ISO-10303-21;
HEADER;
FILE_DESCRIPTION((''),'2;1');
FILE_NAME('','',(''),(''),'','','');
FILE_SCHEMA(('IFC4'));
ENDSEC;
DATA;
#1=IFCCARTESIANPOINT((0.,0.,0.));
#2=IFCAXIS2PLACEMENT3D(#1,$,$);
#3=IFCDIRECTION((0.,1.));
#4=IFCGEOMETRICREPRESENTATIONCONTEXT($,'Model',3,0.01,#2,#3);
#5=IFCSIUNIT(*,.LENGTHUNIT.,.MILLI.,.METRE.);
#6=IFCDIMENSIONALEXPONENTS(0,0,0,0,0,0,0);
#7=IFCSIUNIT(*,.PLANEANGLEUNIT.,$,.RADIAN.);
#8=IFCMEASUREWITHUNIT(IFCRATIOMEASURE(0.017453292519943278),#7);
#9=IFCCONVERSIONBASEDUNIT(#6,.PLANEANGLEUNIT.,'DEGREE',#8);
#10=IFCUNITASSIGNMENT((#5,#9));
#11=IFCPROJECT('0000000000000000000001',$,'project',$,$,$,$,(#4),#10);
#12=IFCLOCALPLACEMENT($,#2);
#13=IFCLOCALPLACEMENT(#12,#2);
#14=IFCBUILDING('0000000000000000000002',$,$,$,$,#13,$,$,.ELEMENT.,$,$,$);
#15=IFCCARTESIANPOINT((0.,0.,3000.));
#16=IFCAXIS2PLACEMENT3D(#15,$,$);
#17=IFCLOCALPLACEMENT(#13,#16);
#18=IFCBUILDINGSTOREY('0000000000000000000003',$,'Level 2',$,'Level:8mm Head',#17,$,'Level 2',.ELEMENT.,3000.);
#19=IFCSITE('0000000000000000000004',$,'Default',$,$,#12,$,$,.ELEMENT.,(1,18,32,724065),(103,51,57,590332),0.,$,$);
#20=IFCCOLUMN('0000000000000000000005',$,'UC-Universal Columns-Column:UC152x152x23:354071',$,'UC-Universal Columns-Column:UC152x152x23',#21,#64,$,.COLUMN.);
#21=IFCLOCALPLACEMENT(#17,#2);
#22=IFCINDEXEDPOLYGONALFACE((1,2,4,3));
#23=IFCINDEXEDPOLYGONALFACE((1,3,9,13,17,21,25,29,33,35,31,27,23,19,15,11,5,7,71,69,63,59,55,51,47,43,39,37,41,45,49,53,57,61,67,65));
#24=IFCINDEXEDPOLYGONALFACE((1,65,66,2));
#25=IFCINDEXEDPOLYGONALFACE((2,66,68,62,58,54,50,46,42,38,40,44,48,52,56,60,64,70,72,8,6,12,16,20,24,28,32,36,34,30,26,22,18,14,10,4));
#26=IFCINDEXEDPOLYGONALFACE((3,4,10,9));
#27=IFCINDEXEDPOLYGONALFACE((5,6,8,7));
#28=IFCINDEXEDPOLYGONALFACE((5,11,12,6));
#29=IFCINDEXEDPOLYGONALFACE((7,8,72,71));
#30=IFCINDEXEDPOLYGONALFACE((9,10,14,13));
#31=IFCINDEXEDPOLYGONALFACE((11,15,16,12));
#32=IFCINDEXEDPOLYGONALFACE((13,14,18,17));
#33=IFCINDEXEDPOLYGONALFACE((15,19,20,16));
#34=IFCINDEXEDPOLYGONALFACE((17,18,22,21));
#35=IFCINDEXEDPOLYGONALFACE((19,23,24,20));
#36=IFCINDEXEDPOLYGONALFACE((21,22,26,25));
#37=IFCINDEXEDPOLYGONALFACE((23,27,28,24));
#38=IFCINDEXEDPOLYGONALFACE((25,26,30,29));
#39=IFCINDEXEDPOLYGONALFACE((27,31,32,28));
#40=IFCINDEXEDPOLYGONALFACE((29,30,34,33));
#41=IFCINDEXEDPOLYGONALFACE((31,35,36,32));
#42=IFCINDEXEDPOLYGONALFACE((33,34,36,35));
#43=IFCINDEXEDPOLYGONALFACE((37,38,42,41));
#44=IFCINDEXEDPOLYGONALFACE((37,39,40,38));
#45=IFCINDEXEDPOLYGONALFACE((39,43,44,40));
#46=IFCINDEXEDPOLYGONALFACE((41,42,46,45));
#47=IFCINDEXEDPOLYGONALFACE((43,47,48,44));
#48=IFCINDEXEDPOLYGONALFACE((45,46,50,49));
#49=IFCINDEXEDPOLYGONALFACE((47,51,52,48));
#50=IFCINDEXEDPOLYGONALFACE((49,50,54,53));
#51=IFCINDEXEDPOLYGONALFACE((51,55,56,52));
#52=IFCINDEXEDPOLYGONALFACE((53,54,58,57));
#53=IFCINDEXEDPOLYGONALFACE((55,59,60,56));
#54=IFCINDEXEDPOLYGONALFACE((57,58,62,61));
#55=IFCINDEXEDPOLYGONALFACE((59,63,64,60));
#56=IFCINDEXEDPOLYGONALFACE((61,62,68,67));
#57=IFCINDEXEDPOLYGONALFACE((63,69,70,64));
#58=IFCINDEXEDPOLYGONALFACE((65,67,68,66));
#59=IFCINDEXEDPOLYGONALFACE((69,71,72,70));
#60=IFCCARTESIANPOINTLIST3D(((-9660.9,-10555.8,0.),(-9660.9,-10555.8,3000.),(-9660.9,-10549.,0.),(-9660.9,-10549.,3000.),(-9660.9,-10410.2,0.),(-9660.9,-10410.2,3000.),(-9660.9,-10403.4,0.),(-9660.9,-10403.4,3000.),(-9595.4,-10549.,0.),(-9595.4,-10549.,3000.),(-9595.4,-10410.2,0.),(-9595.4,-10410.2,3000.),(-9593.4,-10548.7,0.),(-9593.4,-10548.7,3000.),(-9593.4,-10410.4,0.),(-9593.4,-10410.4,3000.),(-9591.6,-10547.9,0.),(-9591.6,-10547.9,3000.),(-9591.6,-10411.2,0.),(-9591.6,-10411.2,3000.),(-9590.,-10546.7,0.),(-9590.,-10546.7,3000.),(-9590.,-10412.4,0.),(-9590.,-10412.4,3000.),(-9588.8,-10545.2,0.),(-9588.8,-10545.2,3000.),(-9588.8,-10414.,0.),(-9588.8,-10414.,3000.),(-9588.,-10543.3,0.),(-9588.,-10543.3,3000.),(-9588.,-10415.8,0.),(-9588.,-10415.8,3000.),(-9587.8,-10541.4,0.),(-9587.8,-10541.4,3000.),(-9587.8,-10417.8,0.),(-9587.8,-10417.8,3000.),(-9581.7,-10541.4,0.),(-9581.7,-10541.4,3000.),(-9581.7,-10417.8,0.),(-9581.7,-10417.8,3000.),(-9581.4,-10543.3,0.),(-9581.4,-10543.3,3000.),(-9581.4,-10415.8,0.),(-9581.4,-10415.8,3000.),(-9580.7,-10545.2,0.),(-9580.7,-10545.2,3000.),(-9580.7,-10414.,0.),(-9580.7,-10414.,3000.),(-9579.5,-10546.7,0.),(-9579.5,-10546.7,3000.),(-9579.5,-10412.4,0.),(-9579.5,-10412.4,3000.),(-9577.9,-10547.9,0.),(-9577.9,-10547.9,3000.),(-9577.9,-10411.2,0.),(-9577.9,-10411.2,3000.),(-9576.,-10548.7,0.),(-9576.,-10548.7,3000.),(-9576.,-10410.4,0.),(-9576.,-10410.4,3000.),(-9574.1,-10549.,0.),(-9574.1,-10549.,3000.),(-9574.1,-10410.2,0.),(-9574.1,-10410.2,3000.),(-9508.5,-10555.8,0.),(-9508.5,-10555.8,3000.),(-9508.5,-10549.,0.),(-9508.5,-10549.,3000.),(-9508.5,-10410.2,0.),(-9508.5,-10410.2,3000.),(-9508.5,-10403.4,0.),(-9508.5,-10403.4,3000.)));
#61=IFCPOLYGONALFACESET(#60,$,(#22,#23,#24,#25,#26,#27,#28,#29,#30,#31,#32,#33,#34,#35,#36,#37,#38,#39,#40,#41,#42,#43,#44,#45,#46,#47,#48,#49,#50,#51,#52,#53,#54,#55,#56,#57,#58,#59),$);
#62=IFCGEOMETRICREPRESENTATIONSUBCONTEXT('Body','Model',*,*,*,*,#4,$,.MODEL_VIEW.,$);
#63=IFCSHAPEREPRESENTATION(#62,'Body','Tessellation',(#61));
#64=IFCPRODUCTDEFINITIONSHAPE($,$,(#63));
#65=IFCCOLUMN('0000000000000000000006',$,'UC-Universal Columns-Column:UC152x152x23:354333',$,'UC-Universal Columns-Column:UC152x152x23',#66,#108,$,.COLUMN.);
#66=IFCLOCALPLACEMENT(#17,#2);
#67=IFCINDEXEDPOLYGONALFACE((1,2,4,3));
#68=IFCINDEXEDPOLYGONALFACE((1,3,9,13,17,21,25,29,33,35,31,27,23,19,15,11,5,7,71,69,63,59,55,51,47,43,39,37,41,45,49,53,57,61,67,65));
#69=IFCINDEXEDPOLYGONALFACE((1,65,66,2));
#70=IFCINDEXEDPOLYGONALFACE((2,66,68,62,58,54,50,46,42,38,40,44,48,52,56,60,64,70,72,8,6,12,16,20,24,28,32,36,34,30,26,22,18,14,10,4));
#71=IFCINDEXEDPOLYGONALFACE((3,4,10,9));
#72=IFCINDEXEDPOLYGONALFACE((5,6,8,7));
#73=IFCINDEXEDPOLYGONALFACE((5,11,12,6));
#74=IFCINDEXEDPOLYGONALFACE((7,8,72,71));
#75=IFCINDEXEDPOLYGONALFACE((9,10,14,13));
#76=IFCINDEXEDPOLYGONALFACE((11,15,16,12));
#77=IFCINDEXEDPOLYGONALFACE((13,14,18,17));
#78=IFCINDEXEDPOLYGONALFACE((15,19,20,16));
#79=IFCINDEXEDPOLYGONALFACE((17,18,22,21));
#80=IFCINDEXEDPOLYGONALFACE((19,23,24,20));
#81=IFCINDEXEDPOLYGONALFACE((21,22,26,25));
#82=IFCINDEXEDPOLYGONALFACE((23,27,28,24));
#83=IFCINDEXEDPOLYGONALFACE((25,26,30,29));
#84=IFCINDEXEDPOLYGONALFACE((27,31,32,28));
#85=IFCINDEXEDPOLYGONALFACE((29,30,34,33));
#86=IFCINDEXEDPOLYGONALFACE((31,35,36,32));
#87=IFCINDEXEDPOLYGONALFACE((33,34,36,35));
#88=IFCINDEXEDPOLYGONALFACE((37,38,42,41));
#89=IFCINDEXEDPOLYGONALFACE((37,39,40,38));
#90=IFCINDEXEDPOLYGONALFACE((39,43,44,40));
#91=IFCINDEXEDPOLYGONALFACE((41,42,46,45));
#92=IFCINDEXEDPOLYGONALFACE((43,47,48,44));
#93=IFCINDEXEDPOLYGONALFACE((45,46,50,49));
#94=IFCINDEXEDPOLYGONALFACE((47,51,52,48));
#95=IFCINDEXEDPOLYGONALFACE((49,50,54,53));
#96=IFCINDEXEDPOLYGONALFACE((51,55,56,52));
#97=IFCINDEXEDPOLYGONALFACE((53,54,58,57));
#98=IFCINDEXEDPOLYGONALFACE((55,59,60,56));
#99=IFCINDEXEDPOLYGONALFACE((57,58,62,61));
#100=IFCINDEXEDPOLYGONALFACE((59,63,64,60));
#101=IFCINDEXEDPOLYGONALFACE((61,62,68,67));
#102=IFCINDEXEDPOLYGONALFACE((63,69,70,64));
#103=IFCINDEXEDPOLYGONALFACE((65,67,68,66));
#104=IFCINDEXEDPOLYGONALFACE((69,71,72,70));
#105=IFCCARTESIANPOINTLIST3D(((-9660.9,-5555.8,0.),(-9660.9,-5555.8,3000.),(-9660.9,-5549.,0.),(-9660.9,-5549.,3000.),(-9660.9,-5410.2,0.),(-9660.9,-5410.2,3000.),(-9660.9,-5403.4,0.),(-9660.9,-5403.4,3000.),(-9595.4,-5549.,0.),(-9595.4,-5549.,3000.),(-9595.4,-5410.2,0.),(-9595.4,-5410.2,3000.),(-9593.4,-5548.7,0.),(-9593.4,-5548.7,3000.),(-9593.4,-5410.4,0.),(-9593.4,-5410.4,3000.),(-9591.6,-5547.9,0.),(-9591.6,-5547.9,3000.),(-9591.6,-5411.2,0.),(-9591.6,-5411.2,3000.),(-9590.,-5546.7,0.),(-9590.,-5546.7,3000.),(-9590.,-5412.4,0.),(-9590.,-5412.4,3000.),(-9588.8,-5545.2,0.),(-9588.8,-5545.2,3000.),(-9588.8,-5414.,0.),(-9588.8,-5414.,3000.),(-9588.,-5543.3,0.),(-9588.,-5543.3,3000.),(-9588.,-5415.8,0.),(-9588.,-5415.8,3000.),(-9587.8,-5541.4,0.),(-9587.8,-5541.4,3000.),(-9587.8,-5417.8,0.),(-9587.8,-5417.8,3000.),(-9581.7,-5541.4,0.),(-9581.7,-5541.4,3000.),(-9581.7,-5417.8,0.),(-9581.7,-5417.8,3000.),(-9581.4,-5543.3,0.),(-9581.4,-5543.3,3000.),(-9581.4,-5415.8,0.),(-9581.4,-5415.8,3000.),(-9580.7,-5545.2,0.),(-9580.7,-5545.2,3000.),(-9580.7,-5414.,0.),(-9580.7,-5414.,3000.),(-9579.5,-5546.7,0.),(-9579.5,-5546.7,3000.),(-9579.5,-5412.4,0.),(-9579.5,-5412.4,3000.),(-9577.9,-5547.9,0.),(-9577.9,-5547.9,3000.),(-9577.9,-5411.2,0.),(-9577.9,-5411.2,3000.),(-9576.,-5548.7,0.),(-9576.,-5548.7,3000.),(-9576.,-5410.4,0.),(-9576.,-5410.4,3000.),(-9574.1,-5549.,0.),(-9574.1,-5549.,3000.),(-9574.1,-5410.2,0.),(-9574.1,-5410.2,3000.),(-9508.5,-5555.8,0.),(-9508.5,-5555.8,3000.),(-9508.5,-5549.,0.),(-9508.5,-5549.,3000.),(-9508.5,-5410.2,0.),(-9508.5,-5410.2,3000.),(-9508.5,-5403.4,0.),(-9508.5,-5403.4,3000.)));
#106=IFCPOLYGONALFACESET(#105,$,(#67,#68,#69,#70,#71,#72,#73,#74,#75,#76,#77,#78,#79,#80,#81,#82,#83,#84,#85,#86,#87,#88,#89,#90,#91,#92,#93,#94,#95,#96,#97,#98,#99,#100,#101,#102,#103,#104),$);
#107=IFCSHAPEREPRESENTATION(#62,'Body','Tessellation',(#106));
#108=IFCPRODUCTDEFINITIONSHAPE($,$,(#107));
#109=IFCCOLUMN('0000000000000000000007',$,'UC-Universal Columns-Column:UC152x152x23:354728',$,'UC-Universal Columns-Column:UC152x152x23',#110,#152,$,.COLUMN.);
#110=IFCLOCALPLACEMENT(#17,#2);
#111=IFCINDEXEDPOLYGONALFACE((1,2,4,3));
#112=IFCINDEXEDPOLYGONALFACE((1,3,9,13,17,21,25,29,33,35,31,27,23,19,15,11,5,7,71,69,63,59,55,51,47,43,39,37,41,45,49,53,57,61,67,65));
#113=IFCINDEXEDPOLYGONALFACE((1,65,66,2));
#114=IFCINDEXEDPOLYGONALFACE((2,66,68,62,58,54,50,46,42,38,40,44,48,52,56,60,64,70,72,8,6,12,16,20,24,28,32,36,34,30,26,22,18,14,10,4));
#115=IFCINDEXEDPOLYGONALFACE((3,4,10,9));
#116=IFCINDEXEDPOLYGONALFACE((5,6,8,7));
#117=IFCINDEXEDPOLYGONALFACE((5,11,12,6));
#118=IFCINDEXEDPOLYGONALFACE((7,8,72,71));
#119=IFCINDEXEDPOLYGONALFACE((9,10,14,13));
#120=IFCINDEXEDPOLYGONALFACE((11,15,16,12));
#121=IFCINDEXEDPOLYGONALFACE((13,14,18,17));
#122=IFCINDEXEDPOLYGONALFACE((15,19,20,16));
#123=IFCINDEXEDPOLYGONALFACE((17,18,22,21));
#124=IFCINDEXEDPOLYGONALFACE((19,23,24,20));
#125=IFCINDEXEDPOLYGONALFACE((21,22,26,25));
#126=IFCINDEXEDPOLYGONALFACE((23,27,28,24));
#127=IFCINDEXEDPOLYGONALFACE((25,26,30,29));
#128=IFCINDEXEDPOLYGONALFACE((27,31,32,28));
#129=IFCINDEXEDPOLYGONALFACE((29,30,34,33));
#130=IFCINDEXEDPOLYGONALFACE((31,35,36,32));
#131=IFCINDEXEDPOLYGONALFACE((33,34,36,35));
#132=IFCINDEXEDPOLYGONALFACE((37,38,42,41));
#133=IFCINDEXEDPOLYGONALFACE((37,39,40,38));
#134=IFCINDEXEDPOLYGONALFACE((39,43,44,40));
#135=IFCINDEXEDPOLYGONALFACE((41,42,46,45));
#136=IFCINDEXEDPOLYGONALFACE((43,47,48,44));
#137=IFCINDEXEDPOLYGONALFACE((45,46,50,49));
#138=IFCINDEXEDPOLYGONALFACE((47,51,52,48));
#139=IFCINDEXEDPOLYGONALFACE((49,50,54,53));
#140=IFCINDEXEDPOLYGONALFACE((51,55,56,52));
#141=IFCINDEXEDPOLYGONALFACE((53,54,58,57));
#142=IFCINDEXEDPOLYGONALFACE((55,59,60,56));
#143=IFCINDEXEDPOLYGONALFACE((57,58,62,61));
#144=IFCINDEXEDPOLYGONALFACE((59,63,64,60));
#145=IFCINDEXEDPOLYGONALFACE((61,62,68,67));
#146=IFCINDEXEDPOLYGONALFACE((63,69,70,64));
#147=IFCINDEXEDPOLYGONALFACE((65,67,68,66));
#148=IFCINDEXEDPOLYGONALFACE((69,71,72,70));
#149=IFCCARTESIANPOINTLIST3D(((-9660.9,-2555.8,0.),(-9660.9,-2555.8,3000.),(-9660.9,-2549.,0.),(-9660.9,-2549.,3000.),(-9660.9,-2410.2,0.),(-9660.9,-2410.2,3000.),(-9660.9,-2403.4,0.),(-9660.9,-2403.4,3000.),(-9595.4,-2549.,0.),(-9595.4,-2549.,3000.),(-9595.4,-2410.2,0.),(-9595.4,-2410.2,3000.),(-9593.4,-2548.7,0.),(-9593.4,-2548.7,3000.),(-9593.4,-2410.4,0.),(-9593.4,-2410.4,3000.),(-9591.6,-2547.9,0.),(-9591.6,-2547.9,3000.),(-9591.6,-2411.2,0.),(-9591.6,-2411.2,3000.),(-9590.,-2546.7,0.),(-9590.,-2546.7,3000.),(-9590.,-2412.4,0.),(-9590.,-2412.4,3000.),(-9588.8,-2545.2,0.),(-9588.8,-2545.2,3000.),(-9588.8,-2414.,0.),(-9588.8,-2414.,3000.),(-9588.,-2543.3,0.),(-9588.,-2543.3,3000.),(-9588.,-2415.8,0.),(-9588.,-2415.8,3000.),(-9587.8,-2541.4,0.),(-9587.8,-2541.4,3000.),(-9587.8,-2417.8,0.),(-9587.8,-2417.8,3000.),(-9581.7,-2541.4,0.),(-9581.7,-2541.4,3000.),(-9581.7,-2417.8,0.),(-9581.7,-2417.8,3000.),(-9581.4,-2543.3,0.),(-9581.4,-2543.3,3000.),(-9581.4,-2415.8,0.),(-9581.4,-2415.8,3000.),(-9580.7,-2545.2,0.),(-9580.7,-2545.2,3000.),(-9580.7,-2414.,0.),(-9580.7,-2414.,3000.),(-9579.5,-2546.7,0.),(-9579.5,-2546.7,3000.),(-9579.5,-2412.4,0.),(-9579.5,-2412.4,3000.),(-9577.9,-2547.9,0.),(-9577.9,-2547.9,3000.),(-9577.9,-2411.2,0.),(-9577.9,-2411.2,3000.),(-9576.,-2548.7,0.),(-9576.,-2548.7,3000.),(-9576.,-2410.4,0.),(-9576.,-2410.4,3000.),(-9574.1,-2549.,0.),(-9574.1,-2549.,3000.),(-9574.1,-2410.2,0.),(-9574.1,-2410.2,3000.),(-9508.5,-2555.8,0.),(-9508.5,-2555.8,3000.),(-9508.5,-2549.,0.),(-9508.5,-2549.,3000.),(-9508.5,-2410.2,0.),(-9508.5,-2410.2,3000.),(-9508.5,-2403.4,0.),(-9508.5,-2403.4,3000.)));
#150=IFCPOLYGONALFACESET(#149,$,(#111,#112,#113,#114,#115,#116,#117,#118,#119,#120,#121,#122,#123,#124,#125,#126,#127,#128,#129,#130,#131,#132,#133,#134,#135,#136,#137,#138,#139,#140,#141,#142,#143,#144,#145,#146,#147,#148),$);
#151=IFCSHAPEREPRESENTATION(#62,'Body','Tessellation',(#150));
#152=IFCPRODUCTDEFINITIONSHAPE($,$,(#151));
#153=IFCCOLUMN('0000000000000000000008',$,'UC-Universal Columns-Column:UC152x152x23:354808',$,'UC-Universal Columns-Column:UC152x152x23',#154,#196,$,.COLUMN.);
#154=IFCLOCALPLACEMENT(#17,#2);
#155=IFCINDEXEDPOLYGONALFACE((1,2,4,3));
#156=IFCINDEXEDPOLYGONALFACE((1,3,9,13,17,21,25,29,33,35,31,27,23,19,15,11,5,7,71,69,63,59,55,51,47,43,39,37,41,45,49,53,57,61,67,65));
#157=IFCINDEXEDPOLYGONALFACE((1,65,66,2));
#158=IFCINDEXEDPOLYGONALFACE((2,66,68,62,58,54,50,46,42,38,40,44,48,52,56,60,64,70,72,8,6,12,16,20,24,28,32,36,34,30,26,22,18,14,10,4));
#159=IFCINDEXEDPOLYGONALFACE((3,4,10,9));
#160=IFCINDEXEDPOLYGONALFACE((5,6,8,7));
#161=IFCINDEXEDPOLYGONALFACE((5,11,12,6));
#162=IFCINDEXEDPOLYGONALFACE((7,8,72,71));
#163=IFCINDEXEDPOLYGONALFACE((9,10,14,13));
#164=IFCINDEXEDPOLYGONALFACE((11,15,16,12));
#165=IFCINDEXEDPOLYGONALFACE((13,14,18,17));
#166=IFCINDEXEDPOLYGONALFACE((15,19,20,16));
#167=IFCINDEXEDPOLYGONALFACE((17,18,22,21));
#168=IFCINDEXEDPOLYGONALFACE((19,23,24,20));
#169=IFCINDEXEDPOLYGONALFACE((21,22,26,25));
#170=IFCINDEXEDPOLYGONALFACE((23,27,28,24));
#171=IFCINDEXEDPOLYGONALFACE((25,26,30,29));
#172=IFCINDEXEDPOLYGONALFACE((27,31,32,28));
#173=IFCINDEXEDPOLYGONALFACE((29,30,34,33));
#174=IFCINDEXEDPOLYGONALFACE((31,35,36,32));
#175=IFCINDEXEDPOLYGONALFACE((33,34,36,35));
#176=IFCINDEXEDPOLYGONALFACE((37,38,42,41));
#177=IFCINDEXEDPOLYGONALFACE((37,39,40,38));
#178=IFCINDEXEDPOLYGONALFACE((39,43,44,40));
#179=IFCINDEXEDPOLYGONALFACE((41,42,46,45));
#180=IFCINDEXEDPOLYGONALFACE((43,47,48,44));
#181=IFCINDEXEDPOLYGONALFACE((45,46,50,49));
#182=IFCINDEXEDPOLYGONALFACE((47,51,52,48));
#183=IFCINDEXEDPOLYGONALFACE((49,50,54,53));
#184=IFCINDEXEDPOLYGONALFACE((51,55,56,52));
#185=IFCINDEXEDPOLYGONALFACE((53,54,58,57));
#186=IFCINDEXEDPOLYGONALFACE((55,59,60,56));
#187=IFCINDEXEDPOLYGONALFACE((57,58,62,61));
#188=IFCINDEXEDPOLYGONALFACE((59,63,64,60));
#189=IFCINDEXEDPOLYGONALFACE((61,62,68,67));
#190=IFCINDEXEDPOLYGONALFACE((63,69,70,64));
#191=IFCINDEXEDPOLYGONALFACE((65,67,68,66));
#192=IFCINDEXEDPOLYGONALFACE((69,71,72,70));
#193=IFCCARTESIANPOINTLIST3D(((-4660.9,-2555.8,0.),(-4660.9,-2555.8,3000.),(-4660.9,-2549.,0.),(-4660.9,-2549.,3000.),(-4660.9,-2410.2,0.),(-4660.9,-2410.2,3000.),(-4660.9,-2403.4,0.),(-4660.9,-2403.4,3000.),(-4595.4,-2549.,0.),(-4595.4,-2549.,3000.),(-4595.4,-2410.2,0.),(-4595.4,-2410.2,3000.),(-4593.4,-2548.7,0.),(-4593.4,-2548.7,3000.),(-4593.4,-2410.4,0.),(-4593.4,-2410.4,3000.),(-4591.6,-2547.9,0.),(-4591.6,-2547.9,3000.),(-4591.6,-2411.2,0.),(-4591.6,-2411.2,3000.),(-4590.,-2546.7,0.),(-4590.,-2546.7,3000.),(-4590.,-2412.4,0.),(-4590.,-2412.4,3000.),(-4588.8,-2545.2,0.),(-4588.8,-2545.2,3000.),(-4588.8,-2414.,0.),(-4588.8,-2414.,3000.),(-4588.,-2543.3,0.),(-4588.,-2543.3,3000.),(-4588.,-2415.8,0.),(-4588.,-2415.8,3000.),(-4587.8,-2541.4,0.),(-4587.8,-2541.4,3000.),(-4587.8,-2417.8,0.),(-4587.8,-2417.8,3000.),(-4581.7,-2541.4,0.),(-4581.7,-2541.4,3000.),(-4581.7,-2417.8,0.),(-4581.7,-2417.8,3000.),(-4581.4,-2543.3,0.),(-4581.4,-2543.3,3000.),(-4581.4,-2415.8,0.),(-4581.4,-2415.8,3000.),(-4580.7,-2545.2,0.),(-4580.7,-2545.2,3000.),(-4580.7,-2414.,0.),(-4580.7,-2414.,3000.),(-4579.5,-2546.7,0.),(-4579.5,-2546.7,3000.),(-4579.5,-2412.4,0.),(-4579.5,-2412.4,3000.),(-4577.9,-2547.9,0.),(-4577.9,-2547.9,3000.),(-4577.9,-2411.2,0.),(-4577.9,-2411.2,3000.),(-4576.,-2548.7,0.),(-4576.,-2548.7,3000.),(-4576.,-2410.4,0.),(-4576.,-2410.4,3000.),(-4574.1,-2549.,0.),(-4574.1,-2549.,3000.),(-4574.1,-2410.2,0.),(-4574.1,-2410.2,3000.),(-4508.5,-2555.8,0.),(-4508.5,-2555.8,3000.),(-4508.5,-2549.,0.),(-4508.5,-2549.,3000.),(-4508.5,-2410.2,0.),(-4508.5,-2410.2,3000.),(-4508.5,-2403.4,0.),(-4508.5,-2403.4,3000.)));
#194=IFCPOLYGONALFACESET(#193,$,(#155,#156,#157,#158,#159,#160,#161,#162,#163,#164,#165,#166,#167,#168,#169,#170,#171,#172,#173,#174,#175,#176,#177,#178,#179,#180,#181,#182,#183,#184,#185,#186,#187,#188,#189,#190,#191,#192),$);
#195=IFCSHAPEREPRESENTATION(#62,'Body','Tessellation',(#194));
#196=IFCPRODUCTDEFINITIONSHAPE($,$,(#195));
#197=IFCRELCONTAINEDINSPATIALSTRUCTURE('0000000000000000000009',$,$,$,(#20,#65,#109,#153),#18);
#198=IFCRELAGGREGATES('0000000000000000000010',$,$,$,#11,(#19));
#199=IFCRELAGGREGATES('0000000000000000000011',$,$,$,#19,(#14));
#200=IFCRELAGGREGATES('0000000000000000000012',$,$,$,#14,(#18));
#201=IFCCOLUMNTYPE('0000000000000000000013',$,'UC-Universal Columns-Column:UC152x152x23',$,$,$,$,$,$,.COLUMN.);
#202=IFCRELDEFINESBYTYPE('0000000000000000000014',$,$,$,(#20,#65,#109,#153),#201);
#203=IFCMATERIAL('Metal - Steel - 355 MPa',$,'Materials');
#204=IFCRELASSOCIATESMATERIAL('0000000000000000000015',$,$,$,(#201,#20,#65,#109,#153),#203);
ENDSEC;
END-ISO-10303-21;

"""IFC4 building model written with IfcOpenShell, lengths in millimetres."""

from ifc_helpers import new_model, entity, si_unit, converted_unit, direction, frame, origin, place, context, subcontext, project, spatial, line, arc, indexed_curve, outline, extrude, source, transform, mapped, material, type_object, type_shapes, element, save


model = new_model("IFC4")

# Units and contexts
model_context = context("Model", 3, precision=0.01, world=origin(), true_north=direction((0.0, 1.0)))
body_context = subcontext(model_context, "Body", "Model", "MODEL_VIEW")
ifc_project = project(units=[si_unit("LENGTHUNIT", "METRE", prefix="MILLI"), converted_unit("PLANEANGLEUNIT", "DEGREE", entity("IfcRatioMeasure", 0.017453292519943278), si_unit("PLANEANGLEUNIT", "RADIAN"), dimensions=[0, 0, 0, 0, 0, 0, 0])], contexts=[model_context])

# Site, building, storey
site_placement = place(None, origin())
site = spatial("IfcSite", under=ifc_project, at=site_placement, Name="Default", CompositionType="ELEMENT", RefLatitude=(1, 18, 32, 724065), RefLongitude=(103, 51, 57, 590332), RefElevation=0.0)
building_placement = place(site_placement, origin())
building = spatial("IfcBuilding", under=site, at=building_placement, CompositionType="ELEMENT")
storey_placement = place(building_placement, frame((0.0, 0.0, 3000.0)))
storey = spatial("IfcBuildingStorey", under=building, at=storey_placement, Name="Level 2", ObjectType="Level:8mm Head", LongName="Level 2", CompositionType="ELEMENT", Elevation=3000.0)

# Columns
ifc_material_1 = material(Name="Metal - Steel - 355 MPa", Category="Materials")
column_type = type_object("IfcColumnType", Name="UC-Universal Columns-Column:UC152x152x23", PredefinedType="COLUMN", material=ifc_material_1)
shared_shape_1 = source(origin(), body_context, "Body", "SweptSolid", [
    extrude(outline(indexed_curve([(69.4, -76.2), (76.2, -76.2), (76.2, 76.2), (69.4, 76.2), (69.4, 10.7), (67.2, 5.3), (61.8, 3.1), (-61.8, 3.1), (-67.2, 5.3), (-69.4, 10.7), (-69.4, 76.2), (-76.2, 76.2), (-76.2, -76.2), (-69.4, -76.2), (-69.4, -10.7), (-67.2, -5.3), (-61.8, -3.0), (61.8, -3.1), (67.2, -5.3), (69.4, -10.6)], segments=[line(1, 2, 3, 4, 5), arc(5, 6, 7), line(7, 8), arc(8, 9, 10), line(10, 11, 12, 13, 14, 15), arc(15, 16, 17), line(17, 18), arc(18, 19, 20), line(20, 1)], self_intersect=False)), frame((0.0, 0.0, 3000.0), z_axis=(0.0, 0.0, 1.0), x_axis=(0.0, -1.0, 0.0)), (0.0, 0.0, 1.0), 3000.0),
])
type_shapes(column_type, [shared_shape_1])
for number, where, name in (
    (1, (-9584.7, -10479.6, -3000.0), "UC-Universal Columns-Column:UC152x152x23:354071"),
    (2, (-9584.7, -5479.6, -3000.0), "UC-Universal Columns-Column:UC152x152x23:354333"),
    (3, (-9584.7, -2479.6, -3000.0), "UC-Universal Columns-Column:UC152x152x23:354728"),
    (4, (-4584.7, -2479.6, -3000.0), "UC-Universal Columns-Column:UC152x152x23:354808"),
):
    element("IfcColumn", number, at=place(storey_placement, frame(where)), inside=storey, type_object=column_type, material=ifc_material_1, Name=name, ObjectType="UC-Universal Columns-Column:UC152x152x23", PredefinedType="COLUMN", context=body_context, shape_type="MappedRepresentation", body=[
        mapped(shared_shape_1, transform((0.0, 0.0, 0.0), scale=1.0)),
    ])

save(model, "model.ifc")
